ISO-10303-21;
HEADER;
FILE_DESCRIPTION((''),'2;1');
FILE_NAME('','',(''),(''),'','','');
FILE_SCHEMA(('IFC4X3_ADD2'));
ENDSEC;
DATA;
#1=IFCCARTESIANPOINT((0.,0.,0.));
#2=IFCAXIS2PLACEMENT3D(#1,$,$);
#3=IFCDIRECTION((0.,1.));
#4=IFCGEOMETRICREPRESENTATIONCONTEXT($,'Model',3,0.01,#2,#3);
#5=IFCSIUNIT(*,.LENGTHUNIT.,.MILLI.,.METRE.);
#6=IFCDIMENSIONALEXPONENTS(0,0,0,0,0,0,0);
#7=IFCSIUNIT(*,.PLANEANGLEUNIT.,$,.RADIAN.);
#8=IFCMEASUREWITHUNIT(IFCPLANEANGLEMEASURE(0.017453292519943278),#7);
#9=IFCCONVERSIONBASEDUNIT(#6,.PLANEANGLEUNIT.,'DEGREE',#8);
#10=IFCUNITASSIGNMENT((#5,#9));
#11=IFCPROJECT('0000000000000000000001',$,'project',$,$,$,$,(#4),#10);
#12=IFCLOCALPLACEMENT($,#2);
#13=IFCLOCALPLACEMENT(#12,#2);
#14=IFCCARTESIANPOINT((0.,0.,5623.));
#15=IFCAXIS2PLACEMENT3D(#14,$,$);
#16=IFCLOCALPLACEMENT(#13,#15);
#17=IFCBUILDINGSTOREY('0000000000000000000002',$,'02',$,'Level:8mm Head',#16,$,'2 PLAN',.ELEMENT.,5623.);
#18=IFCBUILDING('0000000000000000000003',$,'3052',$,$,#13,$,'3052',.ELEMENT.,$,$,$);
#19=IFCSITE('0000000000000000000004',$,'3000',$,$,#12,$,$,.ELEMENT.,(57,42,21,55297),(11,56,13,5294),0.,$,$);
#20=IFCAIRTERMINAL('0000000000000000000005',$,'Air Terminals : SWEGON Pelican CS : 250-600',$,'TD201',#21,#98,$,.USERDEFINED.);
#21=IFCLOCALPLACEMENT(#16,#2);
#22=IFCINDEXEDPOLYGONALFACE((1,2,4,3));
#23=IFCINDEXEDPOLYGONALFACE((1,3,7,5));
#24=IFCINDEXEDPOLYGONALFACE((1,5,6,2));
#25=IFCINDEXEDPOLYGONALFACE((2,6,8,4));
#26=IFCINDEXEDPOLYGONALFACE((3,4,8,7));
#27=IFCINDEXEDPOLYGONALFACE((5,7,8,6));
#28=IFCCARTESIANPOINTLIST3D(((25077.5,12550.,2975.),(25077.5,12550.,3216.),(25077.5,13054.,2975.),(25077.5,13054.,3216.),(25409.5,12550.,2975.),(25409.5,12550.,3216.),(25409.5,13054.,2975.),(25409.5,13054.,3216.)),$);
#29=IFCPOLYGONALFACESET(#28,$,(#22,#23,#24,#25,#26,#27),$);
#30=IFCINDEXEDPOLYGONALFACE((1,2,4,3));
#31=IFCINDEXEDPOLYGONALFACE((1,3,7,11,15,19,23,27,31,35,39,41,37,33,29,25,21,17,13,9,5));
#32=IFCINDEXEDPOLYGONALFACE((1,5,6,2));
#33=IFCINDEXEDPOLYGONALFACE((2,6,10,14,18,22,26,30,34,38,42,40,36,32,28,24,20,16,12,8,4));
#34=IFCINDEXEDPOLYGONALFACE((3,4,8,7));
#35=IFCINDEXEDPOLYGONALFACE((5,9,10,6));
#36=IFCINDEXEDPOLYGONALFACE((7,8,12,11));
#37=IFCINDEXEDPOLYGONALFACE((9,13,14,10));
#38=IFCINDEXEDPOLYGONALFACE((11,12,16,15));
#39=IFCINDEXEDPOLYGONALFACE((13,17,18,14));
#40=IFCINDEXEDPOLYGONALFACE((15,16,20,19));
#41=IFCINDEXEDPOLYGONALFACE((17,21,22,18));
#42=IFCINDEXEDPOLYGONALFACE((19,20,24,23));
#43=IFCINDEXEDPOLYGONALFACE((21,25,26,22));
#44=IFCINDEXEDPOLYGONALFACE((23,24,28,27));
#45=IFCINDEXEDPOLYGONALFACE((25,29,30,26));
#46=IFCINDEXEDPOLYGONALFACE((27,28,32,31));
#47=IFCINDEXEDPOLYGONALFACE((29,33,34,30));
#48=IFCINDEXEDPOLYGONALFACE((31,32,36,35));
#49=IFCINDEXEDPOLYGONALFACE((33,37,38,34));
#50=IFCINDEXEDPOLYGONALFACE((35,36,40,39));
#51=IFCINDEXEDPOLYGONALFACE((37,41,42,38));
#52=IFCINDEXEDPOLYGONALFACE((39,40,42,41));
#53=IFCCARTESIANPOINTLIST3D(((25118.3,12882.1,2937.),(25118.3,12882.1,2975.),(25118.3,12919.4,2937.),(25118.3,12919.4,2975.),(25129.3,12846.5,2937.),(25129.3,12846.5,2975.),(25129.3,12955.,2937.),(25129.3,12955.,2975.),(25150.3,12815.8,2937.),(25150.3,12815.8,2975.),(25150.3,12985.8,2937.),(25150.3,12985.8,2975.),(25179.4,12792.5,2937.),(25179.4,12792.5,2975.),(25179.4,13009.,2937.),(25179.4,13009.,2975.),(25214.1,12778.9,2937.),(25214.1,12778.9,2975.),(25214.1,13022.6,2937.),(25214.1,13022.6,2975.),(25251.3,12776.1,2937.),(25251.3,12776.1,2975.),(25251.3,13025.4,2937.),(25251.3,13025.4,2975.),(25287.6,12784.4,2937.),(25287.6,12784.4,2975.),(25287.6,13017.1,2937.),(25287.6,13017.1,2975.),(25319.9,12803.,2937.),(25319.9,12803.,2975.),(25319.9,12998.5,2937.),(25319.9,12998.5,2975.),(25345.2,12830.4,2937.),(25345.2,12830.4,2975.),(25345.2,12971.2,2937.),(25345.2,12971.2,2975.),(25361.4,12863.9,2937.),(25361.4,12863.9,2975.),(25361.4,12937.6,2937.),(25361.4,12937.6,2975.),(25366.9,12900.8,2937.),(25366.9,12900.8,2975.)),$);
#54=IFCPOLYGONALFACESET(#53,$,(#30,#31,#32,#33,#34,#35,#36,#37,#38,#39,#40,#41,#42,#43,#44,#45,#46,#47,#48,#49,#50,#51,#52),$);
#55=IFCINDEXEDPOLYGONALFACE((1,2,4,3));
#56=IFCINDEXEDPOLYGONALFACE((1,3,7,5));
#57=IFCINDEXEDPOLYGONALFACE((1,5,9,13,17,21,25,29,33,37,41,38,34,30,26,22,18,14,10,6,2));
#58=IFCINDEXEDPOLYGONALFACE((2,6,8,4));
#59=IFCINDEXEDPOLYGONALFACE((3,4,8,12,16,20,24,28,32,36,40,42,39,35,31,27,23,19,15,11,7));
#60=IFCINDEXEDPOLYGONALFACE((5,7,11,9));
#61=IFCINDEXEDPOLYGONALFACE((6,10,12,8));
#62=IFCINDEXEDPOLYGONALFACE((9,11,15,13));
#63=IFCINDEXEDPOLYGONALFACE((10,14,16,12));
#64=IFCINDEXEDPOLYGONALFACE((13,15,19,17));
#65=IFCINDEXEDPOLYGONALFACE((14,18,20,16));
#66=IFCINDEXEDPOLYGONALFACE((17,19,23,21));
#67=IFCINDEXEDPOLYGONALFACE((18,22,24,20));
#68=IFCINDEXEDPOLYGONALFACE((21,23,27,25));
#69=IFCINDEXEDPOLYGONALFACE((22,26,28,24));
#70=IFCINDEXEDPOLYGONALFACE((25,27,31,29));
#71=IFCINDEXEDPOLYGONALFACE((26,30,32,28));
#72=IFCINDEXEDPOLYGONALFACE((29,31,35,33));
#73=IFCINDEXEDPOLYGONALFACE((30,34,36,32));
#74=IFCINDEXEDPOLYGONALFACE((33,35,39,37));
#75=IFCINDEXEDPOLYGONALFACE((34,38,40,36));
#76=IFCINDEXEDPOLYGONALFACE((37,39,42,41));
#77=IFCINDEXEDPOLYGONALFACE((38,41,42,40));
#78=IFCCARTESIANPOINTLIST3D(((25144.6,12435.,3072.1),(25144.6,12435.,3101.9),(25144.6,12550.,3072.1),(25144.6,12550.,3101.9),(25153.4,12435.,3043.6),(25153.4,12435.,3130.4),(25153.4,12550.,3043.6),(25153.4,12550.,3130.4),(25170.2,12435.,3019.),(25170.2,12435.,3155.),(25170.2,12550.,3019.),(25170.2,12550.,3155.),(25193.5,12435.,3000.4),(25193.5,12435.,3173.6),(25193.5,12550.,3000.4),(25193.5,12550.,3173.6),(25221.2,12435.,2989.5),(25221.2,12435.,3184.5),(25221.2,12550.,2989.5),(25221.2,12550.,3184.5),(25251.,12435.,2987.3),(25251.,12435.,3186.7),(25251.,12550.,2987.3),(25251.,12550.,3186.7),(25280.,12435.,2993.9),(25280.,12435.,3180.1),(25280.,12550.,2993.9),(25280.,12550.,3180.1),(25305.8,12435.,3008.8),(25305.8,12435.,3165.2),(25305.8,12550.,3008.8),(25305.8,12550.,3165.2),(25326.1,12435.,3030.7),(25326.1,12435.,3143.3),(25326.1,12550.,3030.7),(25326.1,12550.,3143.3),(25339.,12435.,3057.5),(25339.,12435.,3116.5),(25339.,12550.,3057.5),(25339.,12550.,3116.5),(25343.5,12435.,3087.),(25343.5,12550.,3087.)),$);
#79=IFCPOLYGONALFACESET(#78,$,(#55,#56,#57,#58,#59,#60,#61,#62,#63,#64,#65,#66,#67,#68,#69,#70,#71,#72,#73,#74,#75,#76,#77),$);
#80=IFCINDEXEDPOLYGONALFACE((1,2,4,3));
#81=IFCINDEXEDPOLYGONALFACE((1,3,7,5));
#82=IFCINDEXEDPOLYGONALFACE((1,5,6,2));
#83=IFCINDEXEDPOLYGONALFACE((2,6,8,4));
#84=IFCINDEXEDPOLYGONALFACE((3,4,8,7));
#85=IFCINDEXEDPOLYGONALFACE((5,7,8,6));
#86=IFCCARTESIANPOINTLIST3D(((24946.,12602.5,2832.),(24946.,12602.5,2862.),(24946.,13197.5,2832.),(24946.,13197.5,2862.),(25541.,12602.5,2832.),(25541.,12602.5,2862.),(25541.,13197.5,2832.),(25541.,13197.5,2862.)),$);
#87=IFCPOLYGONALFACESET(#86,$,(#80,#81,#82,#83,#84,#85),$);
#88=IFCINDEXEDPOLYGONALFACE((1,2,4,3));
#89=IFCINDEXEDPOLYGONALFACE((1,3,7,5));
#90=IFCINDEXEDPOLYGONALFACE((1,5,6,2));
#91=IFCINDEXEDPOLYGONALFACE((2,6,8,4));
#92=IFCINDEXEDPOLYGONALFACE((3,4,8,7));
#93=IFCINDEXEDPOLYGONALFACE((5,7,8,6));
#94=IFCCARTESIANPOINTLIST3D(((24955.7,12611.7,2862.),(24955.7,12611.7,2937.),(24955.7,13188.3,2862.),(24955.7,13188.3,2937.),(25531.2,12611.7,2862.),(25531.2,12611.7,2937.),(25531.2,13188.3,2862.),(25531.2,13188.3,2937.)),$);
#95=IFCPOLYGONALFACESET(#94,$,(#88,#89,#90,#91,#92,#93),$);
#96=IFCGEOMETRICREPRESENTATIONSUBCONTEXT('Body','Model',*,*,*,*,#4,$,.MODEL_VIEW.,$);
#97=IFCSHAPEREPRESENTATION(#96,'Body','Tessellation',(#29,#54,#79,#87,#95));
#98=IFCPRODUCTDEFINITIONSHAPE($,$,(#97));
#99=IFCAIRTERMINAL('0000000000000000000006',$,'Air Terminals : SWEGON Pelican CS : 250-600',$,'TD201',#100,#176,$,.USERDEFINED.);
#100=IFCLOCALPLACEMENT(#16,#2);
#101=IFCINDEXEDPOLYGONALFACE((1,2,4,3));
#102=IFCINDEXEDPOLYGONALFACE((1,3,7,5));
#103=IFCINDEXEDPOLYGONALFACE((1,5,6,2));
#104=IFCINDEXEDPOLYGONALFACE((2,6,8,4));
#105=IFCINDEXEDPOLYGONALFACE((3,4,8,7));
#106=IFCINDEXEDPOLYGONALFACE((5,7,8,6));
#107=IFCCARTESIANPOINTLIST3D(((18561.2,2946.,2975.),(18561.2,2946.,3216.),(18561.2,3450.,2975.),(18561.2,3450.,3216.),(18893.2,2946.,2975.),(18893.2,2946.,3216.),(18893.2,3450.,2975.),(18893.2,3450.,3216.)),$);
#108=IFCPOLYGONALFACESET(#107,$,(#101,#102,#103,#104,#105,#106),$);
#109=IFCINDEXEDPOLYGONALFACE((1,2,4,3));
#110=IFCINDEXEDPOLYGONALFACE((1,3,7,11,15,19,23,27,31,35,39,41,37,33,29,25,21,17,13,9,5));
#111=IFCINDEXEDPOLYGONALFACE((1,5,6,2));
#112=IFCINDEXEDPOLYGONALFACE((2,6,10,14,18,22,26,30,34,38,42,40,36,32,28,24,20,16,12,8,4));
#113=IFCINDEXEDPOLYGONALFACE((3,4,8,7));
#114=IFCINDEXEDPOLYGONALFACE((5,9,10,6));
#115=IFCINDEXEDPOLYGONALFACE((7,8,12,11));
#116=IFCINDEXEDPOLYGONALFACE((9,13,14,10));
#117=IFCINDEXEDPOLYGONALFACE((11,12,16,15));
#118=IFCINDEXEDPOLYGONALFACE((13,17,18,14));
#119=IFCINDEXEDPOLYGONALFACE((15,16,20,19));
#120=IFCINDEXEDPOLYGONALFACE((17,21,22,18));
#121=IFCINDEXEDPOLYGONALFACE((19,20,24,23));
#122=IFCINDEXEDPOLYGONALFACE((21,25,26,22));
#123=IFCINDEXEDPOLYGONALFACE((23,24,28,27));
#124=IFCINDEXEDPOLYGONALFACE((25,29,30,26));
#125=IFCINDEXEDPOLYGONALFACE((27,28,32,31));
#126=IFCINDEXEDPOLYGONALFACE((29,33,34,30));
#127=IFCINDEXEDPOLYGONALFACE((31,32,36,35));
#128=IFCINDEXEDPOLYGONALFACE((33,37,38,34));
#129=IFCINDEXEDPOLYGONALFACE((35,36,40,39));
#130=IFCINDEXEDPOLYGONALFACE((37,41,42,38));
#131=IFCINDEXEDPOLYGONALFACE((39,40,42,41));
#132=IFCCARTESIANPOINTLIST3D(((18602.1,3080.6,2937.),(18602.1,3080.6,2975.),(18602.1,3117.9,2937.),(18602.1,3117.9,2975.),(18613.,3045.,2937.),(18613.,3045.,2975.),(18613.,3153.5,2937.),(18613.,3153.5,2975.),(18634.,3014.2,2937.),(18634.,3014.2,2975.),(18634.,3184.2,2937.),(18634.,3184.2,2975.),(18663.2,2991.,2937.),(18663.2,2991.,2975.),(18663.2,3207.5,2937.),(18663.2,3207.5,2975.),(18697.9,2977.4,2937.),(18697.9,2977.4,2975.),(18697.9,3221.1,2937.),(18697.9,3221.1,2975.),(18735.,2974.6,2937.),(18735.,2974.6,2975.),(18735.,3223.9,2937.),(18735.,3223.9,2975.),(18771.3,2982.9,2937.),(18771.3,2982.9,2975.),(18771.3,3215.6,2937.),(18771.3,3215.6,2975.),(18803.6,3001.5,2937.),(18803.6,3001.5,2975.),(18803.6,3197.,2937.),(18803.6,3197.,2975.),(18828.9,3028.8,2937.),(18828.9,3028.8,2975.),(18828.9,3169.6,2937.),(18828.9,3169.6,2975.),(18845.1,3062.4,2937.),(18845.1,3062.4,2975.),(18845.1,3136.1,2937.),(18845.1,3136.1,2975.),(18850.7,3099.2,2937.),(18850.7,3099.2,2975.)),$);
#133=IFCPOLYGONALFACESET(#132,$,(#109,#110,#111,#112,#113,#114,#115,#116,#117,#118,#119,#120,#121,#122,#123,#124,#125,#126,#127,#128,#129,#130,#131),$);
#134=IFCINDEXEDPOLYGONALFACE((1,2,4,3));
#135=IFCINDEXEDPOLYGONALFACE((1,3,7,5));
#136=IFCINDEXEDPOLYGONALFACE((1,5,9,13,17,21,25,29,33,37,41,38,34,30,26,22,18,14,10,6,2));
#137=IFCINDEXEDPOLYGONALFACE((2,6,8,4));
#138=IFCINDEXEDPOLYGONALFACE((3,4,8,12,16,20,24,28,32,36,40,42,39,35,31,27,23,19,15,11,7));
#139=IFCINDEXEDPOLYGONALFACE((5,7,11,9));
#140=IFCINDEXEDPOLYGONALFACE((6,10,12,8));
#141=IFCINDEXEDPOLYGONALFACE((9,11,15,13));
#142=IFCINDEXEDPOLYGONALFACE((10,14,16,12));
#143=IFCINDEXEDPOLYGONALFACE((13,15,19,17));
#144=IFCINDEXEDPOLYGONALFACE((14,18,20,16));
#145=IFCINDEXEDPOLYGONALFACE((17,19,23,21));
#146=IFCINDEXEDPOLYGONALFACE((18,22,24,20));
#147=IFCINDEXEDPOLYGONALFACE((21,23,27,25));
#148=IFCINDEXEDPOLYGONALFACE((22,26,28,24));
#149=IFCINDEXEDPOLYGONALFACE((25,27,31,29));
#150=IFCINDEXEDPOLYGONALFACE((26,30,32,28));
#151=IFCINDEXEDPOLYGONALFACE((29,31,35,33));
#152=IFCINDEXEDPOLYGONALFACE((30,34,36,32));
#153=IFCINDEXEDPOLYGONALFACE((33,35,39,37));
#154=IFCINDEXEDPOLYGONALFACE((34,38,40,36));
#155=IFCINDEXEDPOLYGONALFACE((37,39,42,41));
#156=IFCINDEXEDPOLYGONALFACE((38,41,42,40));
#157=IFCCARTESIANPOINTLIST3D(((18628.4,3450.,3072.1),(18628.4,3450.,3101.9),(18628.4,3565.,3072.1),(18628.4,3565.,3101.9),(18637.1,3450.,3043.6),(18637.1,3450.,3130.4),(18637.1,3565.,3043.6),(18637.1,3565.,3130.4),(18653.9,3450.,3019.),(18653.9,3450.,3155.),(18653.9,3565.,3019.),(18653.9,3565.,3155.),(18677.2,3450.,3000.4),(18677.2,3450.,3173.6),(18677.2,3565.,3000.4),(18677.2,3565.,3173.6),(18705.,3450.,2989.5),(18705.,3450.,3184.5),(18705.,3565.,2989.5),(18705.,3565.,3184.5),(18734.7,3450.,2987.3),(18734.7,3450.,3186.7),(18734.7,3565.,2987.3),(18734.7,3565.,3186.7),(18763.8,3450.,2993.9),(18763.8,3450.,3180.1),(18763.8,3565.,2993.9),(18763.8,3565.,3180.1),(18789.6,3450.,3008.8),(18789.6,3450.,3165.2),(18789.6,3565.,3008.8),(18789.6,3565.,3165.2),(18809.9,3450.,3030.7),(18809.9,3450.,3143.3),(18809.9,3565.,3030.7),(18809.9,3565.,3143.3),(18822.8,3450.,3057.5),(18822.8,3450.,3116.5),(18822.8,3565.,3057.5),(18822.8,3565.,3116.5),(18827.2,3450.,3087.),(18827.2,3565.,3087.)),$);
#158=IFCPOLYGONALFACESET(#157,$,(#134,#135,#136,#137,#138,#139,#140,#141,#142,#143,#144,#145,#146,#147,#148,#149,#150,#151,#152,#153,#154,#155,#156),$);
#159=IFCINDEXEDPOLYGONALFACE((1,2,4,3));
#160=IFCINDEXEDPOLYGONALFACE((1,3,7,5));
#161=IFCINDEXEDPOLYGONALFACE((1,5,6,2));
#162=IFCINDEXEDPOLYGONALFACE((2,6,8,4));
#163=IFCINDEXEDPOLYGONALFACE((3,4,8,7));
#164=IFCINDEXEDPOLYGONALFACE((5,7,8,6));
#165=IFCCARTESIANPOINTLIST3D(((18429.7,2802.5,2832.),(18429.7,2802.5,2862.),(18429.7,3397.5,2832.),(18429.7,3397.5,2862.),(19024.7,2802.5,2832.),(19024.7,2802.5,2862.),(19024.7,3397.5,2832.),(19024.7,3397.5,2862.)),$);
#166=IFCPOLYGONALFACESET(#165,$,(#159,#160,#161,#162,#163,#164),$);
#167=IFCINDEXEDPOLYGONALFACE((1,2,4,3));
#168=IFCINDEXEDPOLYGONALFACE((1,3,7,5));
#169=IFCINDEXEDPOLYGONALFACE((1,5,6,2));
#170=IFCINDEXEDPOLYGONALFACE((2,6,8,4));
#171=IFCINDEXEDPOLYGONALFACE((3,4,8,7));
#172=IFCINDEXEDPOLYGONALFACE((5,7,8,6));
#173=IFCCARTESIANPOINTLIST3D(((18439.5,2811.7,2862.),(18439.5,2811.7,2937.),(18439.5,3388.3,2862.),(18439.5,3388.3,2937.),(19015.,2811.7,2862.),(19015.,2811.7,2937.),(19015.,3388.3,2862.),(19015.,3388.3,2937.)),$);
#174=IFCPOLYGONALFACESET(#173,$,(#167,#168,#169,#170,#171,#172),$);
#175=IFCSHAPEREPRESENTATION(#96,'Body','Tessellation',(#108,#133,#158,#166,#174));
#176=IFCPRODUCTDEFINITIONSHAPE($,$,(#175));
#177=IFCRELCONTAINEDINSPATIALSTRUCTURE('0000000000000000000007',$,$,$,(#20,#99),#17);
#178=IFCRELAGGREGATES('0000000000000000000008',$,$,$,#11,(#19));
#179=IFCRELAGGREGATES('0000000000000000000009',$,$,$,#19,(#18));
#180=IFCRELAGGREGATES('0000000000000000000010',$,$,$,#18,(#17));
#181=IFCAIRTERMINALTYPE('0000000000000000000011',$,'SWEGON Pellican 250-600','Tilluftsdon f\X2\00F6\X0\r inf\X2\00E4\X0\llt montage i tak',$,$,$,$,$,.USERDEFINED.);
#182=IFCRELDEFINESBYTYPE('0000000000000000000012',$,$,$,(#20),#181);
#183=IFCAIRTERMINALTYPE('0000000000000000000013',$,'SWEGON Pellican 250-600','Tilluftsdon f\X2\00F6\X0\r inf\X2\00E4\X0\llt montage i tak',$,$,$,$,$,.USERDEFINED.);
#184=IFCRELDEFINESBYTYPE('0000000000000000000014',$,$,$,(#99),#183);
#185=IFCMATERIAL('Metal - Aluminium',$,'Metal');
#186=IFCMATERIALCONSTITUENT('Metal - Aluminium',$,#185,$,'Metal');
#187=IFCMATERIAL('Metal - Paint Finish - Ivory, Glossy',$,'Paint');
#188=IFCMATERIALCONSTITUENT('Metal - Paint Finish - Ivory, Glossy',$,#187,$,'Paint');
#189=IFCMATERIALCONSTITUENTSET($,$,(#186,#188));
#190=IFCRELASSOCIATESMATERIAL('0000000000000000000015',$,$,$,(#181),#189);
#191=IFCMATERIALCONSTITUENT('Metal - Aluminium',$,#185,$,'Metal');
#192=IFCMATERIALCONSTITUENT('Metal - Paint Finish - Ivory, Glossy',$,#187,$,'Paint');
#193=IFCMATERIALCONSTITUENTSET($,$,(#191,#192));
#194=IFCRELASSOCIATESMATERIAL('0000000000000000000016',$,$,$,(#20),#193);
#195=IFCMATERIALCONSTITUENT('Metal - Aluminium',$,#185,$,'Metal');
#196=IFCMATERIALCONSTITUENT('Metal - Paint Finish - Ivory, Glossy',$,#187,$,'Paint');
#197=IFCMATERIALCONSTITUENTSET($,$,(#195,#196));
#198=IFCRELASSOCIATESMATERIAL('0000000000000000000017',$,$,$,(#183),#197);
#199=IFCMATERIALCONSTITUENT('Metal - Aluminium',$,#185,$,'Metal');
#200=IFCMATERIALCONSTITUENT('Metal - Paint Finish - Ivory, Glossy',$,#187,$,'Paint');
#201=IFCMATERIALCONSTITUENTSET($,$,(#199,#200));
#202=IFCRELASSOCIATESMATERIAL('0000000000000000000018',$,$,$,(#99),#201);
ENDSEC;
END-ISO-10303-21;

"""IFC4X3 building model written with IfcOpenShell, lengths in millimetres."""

from ifc_helpers import new_model, entity, si_unit, converted_unit, direction, frame, frame_2d, origin, origin_2d_with_axis, place, context, subcontext, project, spatial, rectangle, circle, extrude, source, transform, mapped, material, constituent, constituent_set, type_object, type_shapes, element, save


model = new_model("IFC4X3")

# Units and contexts
model_context = context("Model", 3, precision=0.01, world=origin(), true_north=direction((0.0, 1.0)))
body_context = subcontext(model_context, "Body", "Model", "MODEL_VIEW")
ifc_project = project(units=[si_unit("LENGTHUNIT", "METRE", prefix="MILLI"), converted_unit("PLANEANGLEUNIT", "DEGREE", entity("IfcPlaneAngleMeasure", 0.017453292519943278), si_unit("PLANEANGLEUNIT", "RADIAN"), dimensions=[0, 0, 0, 0, 0, 0, 0])], contexts=[model_context])

# Site, building, storey
site_placement = place(None, origin())
site = spatial("IfcSite", under=ifc_project, at=site_placement, Name="3000", CompositionType="ELEMENT", RefLatitude=(57, 42, 21, 55297), RefLongitude=(11, 56, 13, 5294), RefElevation=0.0)
building_placement = place(site_placement, origin())
building = spatial("IfcBuilding", under=site, at=building_placement, Name="3052", LongName="3052", CompositionType="ELEMENT")
storey_placement = place(building_placement, frame((0.0, 0.0, 5623.0)))
storey = spatial("IfcBuildingStorey", under=building, at=storey_placement, Name="02", ObjectType="Level:8mm Head", LongName="2 PLAN", CompositionType="ELEMENT", Elevation=5623.0)

# Air terminals
ifc_material_1 = material(Name="Metal - Aluminium", Category="Metal")
ifc_material_2 = material(Name="Metal - Paint Finish - Ivory, Glossy", Category="Paint")
ifc_constituent_1 = constituent(ifc_material_1, Name="Metal - Aluminium", Category="Metal")
ifc_constituent_2 = constituent(ifc_material_2, Name="Metal - Paint Finish - Ivory, Glossy", Category="Paint")
ifc_constituent_set_1 = constituent_set(constituents=[ifc_constituent_1, ifc_constituent_2])
ifc_constituent_3 = constituent(ifc_material_1, Name="Metal - Aluminium", Category="Metal")
ifc_constituent_4 = constituent(ifc_material_2, Name="Metal - Paint Finish - Ivory, Glossy", Category="Paint")
ifc_constituent_set_2 = constituent_set(constituents=[ifc_constituent_3, ifc_constituent_4])
air_terminal_type_1 = type_object("IfcAirTerminalType", Name="SWEGON Pellican 250-600", Description="Tilluftsdon för infällt montage i tak", PredefinedType="USERDEFINED", material=ifc_constituent_set_2)
shared_shape_1 = source(origin(), body_context, "Body", "SweptSolid", [
    extrude(rectangle(XDim=332.0, YDim=504.0, at=origin_2d_with_axis()), frame((0.0, 98.0, -354.0), z_axis=(0.0, 0.0, 1.0), x_axis=(-1.0, 0.0, 0.0)), (0.0, 0.0, 1.0), 241.0),
    extrude(circle(Radius=125.0, at=frame_2d((0.0, 0.0), x_axis=(1.0, 0.0))), frame((-1.6, -0.8, -113.0)), (0.0, 0.0, 1.0), 38.0),
    extrude(circle(Radius=100.0, at=frame_2d((0.0, 0.0), x_axis=(1.0, 0.0))), frame((0.0, 350.0, -225.0), z_axis=(0.0, 1.0, 0.0), x_axis=(1.0, 0.0, 0.0)), (0.0, 0.0, 1.0), 115.0),
    extrude(rectangle(XDim=595.0, YDim=595.0, at=frame_2d((0.0, 0.0), x_axis=(1.0, 0.0))), frame((0.0, 0.0, 0.0), z_axis=(0.0, 0.0, 1.0), x_axis=(-1.0, 0.0, 0.0)), (0.0, 0.0, 1.0), 30.0),
    extrude(rectangle(XDim=575.5, YDim=576.5, at=origin_2d_with_axis()), frame((0.0, 0.0, -75.0), z_axis=(0.0, 0.0, 1.0), x_axis=(-1.0, 0.0, 0.0)), (0.0, 0.0, 1.0), 75.0),
])
type_shapes(air_terminal_type_1, [shared_shape_1])
air_terminal_1_placement = place(storey_placement, frame((25243.5, 12900.0, 2862.0), z_axis=(0.0, 0.0, -1.0), x_axis=(1.0, 0.0, 0.0)))
element("IfcAirTerminal", 1, at=air_terminal_1_placement, inside=storey, type_object=air_terminal_type_1, material=ifc_constituent_set_1, Name="Air Terminals : SWEGON Pelican CS : 250-600", ObjectType="TD201", PredefinedType="USERDEFINED", context=body_context, shape_type="MappedRepresentation", body=[
    mapped(shared_shape_1, transform((0.0, 0.0, 0.0), scale=1.0)),
])
ifc_constituent_5 = constituent(ifc_material_1, Name="Metal - Aluminium", Category="Metal")
ifc_constituent_6 = constituent(ifc_material_2, Name="Metal - Paint Finish - Ivory, Glossy", Category="Paint")
ifc_constituent_set_3 = constituent_set(constituents=[ifc_constituent_5, ifc_constituent_6])
ifc_constituent_7 = constituent(ifc_material_1, Name="Metal - Aluminium", Category="Metal")
ifc_constituent_8 = constituent(ifc_material_2, Name="Metal - Paint Finish - Ivory, Glossy", Category="Paint")
ifc_constituent_set_4 = constituent_set(constituents=[ifc_constituent_7, ifc_constituent_8])
air_terminal_type_2 = type_object("IfcAirTerminalType", Name="SWEGON Pellican 250-600", Description="Tilluftsdon för infällt montage i tak", PredefinedType="USERDEFINED", material=ifc_constituent_set_4)
shared_shape_2 = source(origin(), body_context, "Body", "SweptSolid", [
    extrude(rectangle(XDim=504.0, YDim=332.0, at=origin_2d_with_axis()), frame((0.0, -98.0, -354.0), z_axis=(0.0, 0.0, 1.0), x_axis=(0.0, 1.0, 0.0)), (0.0, 0.0, 1.0), 241.0),
    extrude(circle(Radius=125.0, at=frame_2d((0.0, 0.0), x_axis=(1.0, 0.0))), frame((-1.6, 0.8, -113.0)), (0.0, 0.0, 1.0), 38.0),
    extrude(circle(Radius=100.0, at=frame_2d((0.0, 0.0), x_axis=(1.0, 0.0))), frame((0.0, -465.0, -225.0), z_axis=(0.0, 1.0, 0.0), x_axis=(1.0, 0.0, 0.0)), (0.0, 0.0, 1.0), 115.0),
    extrude(rectangle(XDim=595.0, YDim=595.0, at=frame_2d((0.0, 0.0), x_axis=(1.0, 0.0))), frame((0.0, 0.0, 0.0), z_axis=(0.0, 0.0, 1.0), x_axis=(0.0, 1.0, 0.0)), (0.0, 0.0, 1.0), 30.0),
    extrude(rectangle(XDim=576.5, YDim=575.5, at=origin_2d_with_axis()), frame((0.0, 0.0, -75.0), z_axis=(0.0, 0.0, 1.0), x_axis=(0.0, 1.0, 0.0)), (0.0, 0.0, 1.0), 75.0),
])
type_shapes(air_terminal_type_2, [shared_shape_2])
air_terminal_2_placement = place(storey_placement, frame((18727.2, 3100.0, 2862.0), z_axis=(0.0, 0.0, -1.0), x_axis=(1.0, 0.0, 0.0)))
element("IfcAirTerminal", 2, at=air_terminal_2_placement, inside=storey, type_object=air_terminal_type_2, material=ifc_constituent_set_3, Name="Air Terminals : SWEGON Pelican CS : 250-600", ObjectType="TD201", PredefinedType="USERDEFINED", context=body_context, shape_type="MappedRepresentation", body=[
    mapped(shared_shape_2, transform((0.0, 0.0, 0.0), scale=1.0)),
])

save(model, "model.ifc")
